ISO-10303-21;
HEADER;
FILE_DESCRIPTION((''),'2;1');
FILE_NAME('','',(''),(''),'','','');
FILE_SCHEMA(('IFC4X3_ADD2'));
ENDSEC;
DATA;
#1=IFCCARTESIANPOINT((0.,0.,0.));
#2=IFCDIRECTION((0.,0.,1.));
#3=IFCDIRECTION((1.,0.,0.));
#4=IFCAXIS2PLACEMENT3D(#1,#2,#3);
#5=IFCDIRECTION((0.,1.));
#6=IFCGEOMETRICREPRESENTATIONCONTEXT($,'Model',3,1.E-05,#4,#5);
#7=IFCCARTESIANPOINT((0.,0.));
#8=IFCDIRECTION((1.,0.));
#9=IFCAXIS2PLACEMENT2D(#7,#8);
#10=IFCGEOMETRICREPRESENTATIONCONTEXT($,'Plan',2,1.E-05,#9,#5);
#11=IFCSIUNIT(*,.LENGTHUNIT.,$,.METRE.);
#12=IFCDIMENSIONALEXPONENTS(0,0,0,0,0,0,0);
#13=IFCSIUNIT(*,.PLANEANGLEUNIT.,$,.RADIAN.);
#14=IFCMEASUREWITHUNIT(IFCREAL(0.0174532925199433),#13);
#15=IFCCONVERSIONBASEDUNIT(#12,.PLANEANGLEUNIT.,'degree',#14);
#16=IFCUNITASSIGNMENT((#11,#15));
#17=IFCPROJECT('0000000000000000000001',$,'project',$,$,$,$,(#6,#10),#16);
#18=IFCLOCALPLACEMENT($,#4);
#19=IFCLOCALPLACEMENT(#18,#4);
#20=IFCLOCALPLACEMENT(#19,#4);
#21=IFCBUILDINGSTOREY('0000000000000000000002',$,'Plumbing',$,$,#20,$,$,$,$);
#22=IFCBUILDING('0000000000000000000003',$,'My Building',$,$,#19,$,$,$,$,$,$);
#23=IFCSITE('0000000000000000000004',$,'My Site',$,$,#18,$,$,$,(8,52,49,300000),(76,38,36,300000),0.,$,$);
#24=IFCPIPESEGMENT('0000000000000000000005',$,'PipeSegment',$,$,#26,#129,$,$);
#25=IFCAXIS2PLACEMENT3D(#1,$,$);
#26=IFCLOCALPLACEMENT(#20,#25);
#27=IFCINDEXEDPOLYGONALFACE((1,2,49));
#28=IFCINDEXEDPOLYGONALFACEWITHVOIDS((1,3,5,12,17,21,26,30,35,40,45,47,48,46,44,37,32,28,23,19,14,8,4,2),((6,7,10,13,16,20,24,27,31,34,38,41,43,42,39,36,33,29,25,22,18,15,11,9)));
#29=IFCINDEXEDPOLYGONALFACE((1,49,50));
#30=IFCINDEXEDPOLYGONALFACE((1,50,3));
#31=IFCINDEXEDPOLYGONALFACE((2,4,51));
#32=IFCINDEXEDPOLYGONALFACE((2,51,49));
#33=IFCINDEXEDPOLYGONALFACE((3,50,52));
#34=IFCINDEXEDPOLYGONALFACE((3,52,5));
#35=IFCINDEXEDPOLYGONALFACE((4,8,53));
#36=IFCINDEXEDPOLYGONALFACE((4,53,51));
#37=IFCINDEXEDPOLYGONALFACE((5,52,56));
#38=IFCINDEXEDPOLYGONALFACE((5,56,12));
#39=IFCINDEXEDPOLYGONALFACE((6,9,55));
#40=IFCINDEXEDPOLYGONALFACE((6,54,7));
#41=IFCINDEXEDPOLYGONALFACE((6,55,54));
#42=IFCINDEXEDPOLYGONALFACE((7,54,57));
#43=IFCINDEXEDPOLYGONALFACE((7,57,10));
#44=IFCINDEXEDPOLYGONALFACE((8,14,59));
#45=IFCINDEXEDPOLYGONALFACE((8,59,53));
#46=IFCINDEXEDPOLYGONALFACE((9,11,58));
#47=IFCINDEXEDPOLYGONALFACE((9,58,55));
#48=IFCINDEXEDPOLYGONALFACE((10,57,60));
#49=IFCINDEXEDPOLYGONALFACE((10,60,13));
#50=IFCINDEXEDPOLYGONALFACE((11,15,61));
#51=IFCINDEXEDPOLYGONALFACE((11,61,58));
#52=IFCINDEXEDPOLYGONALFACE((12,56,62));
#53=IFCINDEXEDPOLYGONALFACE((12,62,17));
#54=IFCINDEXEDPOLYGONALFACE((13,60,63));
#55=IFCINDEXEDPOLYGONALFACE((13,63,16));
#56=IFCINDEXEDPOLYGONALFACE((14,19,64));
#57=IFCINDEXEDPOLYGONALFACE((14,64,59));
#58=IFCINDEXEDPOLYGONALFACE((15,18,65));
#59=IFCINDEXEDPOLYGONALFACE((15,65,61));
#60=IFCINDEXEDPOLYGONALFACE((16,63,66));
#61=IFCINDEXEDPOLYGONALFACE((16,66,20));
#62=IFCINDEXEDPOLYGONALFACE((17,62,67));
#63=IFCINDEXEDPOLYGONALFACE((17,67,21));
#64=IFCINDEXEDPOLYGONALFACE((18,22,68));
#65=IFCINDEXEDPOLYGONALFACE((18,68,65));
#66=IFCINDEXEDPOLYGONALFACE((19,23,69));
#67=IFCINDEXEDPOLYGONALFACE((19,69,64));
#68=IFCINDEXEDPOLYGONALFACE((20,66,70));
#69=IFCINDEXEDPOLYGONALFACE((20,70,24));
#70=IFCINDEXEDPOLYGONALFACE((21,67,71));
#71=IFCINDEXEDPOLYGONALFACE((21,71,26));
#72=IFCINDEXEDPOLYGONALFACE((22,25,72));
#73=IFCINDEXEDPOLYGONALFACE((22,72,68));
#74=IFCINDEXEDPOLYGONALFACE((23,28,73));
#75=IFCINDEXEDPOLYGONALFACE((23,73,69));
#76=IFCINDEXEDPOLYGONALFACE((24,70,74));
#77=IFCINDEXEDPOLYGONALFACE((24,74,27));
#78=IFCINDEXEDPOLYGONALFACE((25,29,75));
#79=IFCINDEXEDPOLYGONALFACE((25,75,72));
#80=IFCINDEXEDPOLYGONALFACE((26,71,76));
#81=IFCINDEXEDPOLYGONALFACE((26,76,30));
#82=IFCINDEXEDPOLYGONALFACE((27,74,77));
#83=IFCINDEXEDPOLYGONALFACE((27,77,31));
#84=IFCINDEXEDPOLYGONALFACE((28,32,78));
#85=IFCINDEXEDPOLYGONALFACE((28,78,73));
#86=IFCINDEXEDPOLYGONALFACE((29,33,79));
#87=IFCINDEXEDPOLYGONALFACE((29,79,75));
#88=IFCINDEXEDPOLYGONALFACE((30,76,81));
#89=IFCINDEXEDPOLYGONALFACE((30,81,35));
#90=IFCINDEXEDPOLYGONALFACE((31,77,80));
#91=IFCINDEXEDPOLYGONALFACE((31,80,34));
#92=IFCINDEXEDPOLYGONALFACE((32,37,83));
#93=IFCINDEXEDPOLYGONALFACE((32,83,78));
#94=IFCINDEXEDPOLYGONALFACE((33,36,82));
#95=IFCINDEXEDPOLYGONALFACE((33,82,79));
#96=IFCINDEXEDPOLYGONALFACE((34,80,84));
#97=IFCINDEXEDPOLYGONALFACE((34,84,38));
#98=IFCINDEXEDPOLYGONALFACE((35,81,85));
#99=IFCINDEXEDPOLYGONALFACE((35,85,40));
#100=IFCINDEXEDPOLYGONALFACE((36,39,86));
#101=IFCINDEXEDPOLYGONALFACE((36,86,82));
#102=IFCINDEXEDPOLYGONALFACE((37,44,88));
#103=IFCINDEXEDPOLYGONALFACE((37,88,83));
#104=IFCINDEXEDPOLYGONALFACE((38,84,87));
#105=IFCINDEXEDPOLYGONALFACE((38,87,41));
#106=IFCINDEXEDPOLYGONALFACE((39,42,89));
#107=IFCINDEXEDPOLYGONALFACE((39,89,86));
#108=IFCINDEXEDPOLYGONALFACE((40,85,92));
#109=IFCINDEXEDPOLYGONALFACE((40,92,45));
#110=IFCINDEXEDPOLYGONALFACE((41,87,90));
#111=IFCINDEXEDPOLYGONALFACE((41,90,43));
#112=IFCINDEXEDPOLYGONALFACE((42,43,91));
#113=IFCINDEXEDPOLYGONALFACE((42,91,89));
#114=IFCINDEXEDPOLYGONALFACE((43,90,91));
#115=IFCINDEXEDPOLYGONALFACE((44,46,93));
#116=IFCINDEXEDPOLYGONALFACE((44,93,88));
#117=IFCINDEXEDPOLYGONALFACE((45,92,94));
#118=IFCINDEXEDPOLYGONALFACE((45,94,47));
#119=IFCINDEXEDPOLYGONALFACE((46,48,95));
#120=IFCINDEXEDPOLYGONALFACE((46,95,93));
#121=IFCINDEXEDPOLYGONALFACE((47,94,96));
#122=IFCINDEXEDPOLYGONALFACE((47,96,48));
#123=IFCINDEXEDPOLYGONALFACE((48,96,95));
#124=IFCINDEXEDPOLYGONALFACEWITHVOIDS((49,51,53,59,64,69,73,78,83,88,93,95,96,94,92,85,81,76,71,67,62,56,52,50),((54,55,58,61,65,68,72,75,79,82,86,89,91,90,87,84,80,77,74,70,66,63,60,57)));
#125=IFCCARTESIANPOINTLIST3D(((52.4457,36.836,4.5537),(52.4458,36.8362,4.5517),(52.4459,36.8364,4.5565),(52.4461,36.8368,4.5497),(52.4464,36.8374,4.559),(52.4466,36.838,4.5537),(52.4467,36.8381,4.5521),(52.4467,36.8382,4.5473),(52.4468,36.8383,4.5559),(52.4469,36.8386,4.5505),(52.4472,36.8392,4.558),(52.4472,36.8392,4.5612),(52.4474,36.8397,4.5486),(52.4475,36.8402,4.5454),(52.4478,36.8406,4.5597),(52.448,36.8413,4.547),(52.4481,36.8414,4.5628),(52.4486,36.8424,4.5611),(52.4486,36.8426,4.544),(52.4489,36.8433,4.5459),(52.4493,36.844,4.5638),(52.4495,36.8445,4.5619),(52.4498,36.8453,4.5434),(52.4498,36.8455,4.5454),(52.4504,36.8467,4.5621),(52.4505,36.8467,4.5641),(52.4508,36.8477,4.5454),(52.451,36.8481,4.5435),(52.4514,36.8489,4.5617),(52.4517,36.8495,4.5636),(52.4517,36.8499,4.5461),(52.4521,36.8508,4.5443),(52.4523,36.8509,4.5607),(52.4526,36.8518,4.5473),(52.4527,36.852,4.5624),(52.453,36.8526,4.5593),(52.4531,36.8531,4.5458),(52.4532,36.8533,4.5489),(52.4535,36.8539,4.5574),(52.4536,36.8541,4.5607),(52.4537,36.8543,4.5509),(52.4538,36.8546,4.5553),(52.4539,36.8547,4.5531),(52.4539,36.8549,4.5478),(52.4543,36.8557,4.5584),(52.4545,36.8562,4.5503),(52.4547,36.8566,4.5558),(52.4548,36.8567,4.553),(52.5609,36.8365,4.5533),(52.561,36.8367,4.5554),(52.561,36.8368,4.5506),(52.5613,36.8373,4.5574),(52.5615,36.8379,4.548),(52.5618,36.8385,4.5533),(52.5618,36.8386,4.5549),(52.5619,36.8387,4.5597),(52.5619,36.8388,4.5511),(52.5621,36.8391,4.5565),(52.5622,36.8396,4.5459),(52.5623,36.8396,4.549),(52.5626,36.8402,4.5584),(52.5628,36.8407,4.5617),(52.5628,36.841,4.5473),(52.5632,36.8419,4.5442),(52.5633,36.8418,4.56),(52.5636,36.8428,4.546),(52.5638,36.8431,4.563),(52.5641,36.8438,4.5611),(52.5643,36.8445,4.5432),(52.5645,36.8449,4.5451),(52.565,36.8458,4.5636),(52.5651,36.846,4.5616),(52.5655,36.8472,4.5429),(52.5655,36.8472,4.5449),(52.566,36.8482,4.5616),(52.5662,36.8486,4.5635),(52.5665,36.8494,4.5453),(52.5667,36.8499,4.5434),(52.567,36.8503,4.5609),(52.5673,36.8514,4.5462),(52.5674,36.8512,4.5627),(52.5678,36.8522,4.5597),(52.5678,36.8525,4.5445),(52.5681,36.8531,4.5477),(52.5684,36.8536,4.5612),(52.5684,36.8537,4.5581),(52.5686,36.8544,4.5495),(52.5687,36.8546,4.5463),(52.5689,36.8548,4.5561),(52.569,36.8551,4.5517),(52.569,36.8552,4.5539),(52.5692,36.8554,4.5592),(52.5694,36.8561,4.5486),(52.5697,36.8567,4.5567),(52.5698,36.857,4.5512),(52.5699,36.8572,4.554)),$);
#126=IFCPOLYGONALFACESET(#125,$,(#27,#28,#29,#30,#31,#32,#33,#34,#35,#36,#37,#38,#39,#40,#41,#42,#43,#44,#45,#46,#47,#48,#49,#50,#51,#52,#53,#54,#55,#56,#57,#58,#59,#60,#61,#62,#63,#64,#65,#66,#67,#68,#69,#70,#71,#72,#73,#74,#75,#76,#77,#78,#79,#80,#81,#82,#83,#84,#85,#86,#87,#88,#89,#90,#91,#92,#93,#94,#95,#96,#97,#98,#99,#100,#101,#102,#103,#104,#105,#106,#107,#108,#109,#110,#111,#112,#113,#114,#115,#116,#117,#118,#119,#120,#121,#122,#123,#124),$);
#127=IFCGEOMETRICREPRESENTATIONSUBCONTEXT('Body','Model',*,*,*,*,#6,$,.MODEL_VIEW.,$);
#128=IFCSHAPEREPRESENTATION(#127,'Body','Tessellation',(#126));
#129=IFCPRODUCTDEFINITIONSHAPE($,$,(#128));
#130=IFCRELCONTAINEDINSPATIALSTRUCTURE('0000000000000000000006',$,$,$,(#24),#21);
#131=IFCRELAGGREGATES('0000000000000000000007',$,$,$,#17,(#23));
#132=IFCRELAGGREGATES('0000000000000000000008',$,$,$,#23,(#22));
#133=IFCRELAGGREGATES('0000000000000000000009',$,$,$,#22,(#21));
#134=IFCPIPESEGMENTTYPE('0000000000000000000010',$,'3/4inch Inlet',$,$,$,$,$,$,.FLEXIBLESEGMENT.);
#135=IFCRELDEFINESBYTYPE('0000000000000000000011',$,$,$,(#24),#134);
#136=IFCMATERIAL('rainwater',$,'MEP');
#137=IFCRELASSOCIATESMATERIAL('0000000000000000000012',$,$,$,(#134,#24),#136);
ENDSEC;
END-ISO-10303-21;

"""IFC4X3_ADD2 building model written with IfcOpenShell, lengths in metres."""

from ifc_helpers import new_model, entity, si_unit, converted_unit, direction, frame, origin_with_axes, origin_2d_with_axis, place, context, subcontext, project, spatial, hollow_circle, extrude, clip, halfspace, material, material_profile, profile_set, profile_usage, type_object, element, save


model = new_model("IFC4X3_ADD2")

# Units and contexts
model_context = context("Model", 3, precision=1e-05, world=origin_with_axes(), true_north=direction((0.0, 1.0)))
plan_context = context("Plan", 2, precision=1e-05, world=origin_2d_with_axis(), true_north=direction((0.0, 1.0)))
body_context_1 = subcontext(model_context, "Body", "Model", "MODEL_VIEW")
ifc_project = project(units=[si_unit("LENGTHUNIT", "METRE"), converted_unit("PLANEANGLEUNIT", "degree", entity("IfcReal", 0.0174532925199433), si_unit("PLANEANGLEUNIT", "RADIAN"), dimensions=[0, 0, 0, 0, 0, 0, 0])], contexts=[model_context, plan_context])

# Site, building, storey
site_placement = place(None, origin_with_axes())
site = spatial("IfcSite", under=ifc_project, at=site_placement, Name="My Site", RefLatitude=(8, 52, 49, 300000), RefLongitude=(76, 38, 36, 300000), RefElevation=0.0)
building_placement = place(site_placement, origin_with_axes())
building = spatial("IfcBuilding", under=site, at=building_placement, Name="My Building")
storey_placement = place(building_placement, origin_with_axes())
storey = spatial("IfcBuildingStorey", under=building, at=storey_placement, Name="Plumbing")

# Pipe segment
ifc_material_1 = material(Name="rainwater", Category="MEP")
ifc_material_profile_1 = material_profile(ifc_material_1, hollow_circle(Radius=0.0104, WallThickness=0.002))
ifc_profile_set_1 = profile_set([ifc_material_profile_1], Name="water")
pipe_segment_type_1 = type_object("IfcPipeSegmentType", Name="3/4inch Inlet", PredefinedType="FLEXIBLESEGMENT", material=ifc_profile_set_1)
ifc_profile_usage_1 = profile_usage(ifc_profile_set_1, cardinal=5)
pipe_segment_1_placement = place(storey_placement, frame((52.5861, 36.8469, 4.5532), z_axis=(-0.999985, -0.004187, 0.003595), x_axis=(0.004187, -0.999991, 0.0)))
element("IfcPipeSegment", 1, at=pipe_segment_1_placement, inside=storey, type_object=pipe_segment_type_1, material=ifc_profile_usage_1, Name="PipeSegment", context=body_context_1, shape_type="Clipping", body=[
    clip(clip(extrude(hollow_circle(Radius=0.0104, WallThickness=0.002), origin_with_axes(), (0.0, 0.0, 1.0), 0.1566), halfspace(frame((-0.0094, -0.0311, 0.0167), z_axis=(0.402001, -0.001685, -0.915637), x_axis=(-0.004193, -0.999991, 0.0)), False)), halfspace(frame((0.0032, -0.0311, 0.1373), z_axis=(-0.402001, 0.001685, 0.915637), x_axis=(0.004193, 0.999991, 0.0)), False)),
])

save(model, "model.ifc")
